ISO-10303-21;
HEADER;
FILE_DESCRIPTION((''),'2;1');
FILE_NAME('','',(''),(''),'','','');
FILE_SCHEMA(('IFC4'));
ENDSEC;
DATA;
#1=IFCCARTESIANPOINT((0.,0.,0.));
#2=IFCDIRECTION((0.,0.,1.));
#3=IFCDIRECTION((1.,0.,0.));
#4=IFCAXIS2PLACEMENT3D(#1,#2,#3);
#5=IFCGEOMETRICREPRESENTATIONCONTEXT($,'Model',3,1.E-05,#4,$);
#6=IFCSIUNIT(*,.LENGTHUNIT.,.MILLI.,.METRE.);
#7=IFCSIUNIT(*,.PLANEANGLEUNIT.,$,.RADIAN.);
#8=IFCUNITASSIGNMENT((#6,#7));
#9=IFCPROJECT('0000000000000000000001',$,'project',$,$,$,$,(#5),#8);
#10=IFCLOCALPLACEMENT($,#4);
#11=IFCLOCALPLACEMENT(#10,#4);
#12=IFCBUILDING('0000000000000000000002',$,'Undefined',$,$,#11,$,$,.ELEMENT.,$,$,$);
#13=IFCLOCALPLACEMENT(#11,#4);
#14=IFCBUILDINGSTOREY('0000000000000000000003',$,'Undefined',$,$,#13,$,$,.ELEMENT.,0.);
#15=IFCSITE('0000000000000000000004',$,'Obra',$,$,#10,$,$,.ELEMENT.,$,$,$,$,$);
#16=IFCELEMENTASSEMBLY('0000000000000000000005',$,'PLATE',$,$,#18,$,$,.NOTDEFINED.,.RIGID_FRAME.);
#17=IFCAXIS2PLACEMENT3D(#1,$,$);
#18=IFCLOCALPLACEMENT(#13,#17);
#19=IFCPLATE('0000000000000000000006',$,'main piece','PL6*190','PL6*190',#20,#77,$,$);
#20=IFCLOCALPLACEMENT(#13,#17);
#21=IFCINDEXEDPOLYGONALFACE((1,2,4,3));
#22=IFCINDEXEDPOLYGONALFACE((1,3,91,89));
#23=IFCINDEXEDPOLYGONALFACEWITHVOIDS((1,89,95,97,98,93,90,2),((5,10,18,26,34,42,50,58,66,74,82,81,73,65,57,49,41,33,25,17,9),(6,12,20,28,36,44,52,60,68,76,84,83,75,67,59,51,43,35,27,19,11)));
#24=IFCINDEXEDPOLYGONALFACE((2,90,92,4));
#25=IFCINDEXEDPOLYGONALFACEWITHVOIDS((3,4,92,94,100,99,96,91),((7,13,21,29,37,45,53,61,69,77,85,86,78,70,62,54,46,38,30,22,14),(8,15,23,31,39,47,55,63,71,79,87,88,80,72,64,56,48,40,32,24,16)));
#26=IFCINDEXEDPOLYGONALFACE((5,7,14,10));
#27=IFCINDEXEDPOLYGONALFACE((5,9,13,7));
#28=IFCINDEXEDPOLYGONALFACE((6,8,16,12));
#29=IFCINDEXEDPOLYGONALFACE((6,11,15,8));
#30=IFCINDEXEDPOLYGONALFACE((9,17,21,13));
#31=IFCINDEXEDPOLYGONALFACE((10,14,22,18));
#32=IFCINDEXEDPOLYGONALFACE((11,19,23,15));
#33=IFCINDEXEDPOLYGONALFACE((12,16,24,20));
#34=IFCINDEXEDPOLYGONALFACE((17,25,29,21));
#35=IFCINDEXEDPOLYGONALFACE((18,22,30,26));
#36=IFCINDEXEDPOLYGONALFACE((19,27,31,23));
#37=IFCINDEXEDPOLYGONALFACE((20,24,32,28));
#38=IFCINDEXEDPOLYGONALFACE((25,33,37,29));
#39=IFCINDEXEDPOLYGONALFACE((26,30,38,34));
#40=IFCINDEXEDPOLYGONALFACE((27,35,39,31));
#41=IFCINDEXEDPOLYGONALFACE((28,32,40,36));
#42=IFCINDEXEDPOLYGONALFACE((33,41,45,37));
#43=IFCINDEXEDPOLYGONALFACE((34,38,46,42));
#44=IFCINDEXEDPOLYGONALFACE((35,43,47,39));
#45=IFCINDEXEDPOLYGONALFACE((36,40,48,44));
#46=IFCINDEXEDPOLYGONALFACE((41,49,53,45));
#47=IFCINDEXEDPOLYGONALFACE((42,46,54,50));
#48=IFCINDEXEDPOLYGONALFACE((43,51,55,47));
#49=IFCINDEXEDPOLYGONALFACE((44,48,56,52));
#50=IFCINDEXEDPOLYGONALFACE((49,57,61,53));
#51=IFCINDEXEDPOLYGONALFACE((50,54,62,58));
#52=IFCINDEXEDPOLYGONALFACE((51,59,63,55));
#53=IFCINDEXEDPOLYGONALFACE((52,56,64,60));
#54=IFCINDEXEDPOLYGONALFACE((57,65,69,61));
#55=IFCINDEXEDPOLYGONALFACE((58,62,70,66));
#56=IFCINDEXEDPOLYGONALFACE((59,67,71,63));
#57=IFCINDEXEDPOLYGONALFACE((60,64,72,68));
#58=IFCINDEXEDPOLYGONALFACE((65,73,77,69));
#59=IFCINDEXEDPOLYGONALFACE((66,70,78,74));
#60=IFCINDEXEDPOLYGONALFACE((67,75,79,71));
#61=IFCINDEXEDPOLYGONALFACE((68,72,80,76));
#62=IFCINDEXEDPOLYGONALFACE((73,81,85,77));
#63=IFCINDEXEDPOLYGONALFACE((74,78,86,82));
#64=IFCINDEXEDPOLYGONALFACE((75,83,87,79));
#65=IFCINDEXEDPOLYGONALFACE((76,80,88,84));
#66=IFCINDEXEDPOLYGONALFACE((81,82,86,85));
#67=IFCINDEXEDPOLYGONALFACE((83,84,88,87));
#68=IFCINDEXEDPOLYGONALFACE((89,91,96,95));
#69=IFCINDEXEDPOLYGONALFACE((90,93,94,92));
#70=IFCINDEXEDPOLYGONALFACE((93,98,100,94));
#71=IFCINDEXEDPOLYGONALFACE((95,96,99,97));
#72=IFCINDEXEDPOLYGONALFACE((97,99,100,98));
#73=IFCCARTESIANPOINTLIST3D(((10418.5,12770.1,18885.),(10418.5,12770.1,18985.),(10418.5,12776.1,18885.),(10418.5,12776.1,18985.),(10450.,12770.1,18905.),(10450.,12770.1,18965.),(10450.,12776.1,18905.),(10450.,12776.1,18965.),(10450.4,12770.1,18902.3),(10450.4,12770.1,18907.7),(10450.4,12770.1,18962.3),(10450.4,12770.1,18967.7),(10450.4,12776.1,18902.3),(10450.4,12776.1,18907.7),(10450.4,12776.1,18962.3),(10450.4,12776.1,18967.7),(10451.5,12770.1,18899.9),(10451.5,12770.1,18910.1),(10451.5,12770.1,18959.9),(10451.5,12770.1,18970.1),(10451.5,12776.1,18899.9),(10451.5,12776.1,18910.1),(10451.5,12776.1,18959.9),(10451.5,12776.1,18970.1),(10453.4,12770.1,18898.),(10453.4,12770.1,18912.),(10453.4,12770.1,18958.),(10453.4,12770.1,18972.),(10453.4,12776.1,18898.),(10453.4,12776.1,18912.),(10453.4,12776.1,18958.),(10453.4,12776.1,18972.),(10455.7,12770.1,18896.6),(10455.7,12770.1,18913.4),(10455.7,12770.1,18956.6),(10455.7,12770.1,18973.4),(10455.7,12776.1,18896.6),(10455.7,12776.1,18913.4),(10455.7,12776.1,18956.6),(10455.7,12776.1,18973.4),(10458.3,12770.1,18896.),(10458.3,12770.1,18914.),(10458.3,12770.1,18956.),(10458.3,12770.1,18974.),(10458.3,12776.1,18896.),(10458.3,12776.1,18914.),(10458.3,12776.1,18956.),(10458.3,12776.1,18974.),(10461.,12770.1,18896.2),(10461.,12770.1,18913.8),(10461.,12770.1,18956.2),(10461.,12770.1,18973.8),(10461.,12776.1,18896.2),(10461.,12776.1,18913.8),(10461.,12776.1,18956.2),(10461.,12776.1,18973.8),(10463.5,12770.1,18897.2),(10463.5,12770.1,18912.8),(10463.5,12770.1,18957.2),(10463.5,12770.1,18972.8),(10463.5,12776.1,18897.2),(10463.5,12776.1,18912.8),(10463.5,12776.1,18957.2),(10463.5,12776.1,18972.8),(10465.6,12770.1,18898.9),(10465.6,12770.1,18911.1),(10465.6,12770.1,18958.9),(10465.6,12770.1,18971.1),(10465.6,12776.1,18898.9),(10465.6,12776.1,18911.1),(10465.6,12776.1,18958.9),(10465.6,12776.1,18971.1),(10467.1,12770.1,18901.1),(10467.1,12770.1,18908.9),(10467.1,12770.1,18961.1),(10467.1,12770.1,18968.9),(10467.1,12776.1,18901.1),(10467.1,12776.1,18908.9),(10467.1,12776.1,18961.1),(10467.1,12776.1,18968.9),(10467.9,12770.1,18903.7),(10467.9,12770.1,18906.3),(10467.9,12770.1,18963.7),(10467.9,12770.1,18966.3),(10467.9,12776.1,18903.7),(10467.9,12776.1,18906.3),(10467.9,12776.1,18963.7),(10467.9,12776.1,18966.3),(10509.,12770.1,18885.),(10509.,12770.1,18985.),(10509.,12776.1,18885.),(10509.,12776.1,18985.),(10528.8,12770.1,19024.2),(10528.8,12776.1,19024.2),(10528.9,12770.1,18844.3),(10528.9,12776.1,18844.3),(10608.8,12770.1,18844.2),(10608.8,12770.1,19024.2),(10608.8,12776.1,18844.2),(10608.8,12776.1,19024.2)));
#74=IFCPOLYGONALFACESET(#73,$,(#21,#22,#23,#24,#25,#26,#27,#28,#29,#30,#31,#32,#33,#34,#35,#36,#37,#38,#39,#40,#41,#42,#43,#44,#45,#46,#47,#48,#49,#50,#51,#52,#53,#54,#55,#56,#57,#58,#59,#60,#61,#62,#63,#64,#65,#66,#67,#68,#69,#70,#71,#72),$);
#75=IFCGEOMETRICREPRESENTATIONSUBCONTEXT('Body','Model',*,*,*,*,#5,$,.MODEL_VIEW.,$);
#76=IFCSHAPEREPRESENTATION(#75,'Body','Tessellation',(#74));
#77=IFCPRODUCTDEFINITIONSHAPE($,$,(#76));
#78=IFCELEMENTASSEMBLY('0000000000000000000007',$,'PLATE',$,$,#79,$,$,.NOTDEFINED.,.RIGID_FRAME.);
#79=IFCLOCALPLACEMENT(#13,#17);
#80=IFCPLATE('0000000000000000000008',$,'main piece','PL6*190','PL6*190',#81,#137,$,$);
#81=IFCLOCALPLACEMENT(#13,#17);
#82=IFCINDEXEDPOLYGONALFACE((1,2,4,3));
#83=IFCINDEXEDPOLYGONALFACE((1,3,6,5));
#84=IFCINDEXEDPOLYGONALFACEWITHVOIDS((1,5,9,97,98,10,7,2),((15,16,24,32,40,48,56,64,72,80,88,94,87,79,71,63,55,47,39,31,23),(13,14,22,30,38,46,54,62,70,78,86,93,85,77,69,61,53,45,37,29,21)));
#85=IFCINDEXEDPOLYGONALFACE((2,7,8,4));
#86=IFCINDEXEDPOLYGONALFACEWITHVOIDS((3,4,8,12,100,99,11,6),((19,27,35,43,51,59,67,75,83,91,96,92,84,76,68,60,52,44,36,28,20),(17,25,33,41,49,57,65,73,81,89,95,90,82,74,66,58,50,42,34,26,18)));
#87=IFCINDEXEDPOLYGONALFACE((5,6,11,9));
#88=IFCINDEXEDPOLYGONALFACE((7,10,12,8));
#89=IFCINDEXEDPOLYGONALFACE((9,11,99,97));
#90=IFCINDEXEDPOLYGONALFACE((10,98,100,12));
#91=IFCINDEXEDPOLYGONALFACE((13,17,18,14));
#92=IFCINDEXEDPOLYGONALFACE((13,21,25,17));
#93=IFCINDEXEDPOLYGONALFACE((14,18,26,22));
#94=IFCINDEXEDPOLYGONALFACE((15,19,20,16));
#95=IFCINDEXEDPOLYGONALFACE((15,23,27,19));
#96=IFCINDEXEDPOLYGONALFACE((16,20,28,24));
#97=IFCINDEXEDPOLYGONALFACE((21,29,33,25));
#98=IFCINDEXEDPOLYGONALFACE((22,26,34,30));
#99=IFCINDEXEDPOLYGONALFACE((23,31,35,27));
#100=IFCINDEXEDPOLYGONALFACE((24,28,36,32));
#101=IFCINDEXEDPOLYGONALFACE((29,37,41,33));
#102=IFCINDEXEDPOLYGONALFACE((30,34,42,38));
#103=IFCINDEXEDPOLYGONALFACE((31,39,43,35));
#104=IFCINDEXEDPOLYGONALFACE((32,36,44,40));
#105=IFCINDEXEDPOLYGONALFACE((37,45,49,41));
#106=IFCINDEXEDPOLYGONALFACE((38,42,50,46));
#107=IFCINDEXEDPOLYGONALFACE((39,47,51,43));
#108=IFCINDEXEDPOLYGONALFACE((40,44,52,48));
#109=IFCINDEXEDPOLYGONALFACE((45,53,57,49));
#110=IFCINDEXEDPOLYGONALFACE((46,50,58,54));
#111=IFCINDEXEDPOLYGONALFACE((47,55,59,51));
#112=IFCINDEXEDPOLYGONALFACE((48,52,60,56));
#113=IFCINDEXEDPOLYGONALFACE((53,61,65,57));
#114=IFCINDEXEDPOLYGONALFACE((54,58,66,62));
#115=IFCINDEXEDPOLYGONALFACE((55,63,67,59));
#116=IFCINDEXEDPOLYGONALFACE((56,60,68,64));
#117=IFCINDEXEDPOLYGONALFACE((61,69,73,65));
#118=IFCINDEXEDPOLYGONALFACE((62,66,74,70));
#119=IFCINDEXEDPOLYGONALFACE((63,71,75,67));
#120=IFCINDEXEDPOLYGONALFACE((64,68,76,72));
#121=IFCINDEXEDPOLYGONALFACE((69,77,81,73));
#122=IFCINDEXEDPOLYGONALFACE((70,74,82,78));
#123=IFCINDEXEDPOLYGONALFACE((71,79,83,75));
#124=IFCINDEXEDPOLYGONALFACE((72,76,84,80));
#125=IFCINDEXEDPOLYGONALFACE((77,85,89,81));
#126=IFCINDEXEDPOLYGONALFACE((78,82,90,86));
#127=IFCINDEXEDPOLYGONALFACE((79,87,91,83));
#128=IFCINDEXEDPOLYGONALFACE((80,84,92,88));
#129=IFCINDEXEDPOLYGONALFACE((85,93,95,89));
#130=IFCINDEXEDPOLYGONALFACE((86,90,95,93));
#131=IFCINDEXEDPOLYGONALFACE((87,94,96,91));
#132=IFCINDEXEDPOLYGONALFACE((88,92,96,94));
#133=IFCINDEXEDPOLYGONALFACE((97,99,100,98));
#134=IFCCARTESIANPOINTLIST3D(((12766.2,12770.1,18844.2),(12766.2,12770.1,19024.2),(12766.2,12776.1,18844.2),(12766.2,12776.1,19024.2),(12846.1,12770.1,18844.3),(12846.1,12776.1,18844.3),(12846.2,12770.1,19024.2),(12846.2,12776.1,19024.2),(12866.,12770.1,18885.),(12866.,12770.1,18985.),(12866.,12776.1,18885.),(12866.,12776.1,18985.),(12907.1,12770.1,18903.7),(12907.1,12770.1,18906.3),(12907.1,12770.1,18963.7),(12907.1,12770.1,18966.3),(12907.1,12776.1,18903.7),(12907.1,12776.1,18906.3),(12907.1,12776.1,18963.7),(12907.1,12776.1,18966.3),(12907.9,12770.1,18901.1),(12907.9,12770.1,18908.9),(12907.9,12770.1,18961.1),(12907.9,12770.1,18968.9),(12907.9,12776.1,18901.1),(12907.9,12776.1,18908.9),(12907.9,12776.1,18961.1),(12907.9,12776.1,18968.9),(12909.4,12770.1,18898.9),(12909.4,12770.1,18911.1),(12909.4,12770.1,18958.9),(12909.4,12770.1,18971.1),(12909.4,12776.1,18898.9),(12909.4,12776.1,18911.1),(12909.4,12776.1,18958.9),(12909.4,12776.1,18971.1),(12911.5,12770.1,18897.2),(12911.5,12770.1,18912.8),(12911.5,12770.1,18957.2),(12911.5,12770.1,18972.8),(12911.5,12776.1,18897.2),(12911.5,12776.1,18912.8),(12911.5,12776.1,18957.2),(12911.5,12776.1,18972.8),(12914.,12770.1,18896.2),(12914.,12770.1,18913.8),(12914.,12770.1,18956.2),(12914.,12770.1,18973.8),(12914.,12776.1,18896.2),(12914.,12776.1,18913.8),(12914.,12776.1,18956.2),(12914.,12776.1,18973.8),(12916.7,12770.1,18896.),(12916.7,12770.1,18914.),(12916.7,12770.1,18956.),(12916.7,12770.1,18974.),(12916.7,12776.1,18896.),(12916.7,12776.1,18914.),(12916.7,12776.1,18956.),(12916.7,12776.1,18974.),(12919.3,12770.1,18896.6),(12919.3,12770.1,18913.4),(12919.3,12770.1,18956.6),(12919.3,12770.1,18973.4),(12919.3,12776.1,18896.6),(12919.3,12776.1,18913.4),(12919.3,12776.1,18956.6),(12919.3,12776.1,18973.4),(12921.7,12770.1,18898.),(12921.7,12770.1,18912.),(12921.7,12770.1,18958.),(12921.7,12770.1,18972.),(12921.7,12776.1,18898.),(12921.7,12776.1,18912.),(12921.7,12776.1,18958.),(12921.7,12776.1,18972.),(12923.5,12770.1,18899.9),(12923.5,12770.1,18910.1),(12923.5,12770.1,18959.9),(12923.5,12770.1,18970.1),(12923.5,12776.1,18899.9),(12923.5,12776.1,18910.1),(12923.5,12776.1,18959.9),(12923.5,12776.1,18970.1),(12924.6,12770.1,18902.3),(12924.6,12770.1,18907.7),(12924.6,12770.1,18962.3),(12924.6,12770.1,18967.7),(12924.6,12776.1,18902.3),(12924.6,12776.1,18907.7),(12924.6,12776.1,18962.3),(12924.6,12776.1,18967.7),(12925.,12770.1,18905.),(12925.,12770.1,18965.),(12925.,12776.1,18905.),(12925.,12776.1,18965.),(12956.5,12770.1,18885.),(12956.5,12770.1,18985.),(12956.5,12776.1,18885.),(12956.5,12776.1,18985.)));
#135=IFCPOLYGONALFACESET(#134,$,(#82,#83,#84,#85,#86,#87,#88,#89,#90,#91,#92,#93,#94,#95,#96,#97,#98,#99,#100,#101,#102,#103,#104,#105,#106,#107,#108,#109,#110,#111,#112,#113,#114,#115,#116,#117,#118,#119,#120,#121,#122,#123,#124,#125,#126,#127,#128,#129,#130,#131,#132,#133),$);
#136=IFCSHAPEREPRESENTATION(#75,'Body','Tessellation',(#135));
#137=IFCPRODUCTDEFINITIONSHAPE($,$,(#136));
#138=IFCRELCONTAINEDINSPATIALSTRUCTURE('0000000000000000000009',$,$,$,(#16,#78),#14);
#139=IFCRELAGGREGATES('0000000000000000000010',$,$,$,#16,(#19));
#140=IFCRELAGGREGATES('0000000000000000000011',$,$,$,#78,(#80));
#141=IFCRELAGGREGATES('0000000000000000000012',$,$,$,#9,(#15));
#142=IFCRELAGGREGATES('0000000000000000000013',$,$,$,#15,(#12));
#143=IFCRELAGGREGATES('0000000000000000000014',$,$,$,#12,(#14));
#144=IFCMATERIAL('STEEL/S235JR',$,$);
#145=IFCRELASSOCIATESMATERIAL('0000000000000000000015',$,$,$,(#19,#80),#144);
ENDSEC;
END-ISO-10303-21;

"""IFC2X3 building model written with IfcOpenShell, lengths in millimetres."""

from ifc_helpers import new_model, si_unit, frame, origin_with_axes, origin_2d_with_axis, place, context, subcontext, project, spatial, polyline, circle, outline, extrude, source, transform, mapped, material, element, aggregate, save


model = new_model("IFC2X3")

# Units and contexts
model_context = context("Model", 3, precision=1e-05, world=origin_with_axes())
body_context = subcontext(model_context, "Body", "Model", "MODEL_VIEW")
ifc_project = project(units=[si_unit("LENGTHUNIT", "METRE", prefix="MILLI"), si_unit("PLANEANGLEUNIT", "RADIAN")], contexts=[model_context])

# Site, building, storey
site_placement = place(None, origin_with_axes())
site = spatial("IfcSite", under=ifc_project, at=site_placement, Name="Obra", CompositionType="ELEMENT")
building_placement = place(site_placement, origin_with_axes())
building = spatial("IfcBuilding", under=site, at=building_placement, Name="Undefined", CompositionType="ELEMENT")
storey_placement = place(building_placement, origin_with_axes())
storey = spatial("IfcBuildingStorey", under=building, at=storey_placement, Name="Undefined", CompositionType="ELEMENT", Elevation=0.0)

# Shared definitions
ifc_material_1 = material(Name="STEEL/S235JR")

# Element assemblies, plates, openings
shared_shape_1 = source(origin_with_axes(), body_context, "Body", "SweptSolid", [
    extrude(circle(Radius=9.0, at=origin_2d_with_axis()), frame((0.0, -6.1, 0.0), z_axis=(0.0, 1.0, 0.0), x_axis=(1.0, 0.0, 0.0)), (0.0, 0.0, 1.0), 6.2),
])
assembly_1_placement = place(storey_placement, origin_with_axes())
assembly_1 = element("IfcElementAssembly", 1, at=assembly_1_placement, inside=storey, Name="PLATE", AssemblyPlace="NOTDEFINED", PredefinedType="RIGID_FRAME")
plate_1_placement = place(assembly_1_placement, frame((10608.8, 12773.1, 19024.2), z_axis=(0.0, 1.0, 0.0), x_axis=(0.0, 0.0, -1.0)))
plate_1 = element("IfcPlate", 2, at=plate_1_placement, material=ifc_material_1, Name="main piece", Description="PL6*190", ObjectType="PL6*190", context=body_context, shape_type="SweptSolid", body=[
    extrude(outline(polyline([(0.0, 0.0), (180.0, 0.0), (180.0, 79.9), (139.2, 99.8), (139.2, 190.3), (39.2, 190.3), (39.2, 99.8), (0.0, 80.0), (0.0, 0.0)])), frame((0.0, 0.0, -3.0), z_axis=(0.0, 0.0, 1.0), x_axis=(1.0, 0.0, 0.0)), (0.0, 0.0, 1.0), 6.0),
])
opening_1_placement = place(assembly_1_placement, frame((10459.0, 12770.1, 18935.0), z_axis=(0.0, 0.0, 1.0), x_axis=(-1.0, 0.0, 0.0)))
element("IfcOpeningElement", 3, at=opening_1_placement, cuts=plate_1, ObjectType="Opening", context=body_context, shape_type="MappedRepresentation", body=[
    mapped(shared_shape_1, transform((0.0, 0.0, -30.0))),
    mapped(shared_shape_1, transform((0.0, 0.0, 30.0))),
])
aggregate(assembly_1, [plate_1])
assembly_2_placement = place(storey_placement, origin_with_axes())
assembly_2 = element("IfcElementAssembly", 4, at=assembly_2_placement, inside=storey, Name="PLATE", AssemblyPlace="NOTDEFINED", PredefinedType="RIGID_FRAME")
plate_2_placement = place(assembly_2_placement, frame((12766.2, 12773.1, 19024.2), z_axis=(0.0, -1.0, 0.0), x_axis=(0.0, 0.0, -1.0)))
plate_2 = element("IfcPlate", 5, at=plate_2_placement, material=ifc_material_1, Name="main piece", Description="PL6*190", ObjectType="PL6*190", context=body_context, shape_type="SweptSolid", body=[
    extrude(outline(polyline([(0.0, 0.0), (180.0, 0.0), (180.0, 79.9), (139.2, 99.8), (139.2, 190.3), (39.2, 190.3), (39.2, 99.8), (0.0, 80.0), (0.0, 0.0)])), frame((0.0, 0.0, -3.0), z_axis=(0.0, 0.0, 1.0), x_axis=(1.0, 0.0, 0.0)), (0.0, 0.0, 1.0), 6.0),
])
opening_2_placement = place(assembly_2_placement, frame((12916.0, 12770.1, 18935.0), z_axis=(0.0, 0.0, -1.0), x_axis=(1.0, 0.0, 0.0)))
element("IfcOpeningElement", 6, at=opening_2_placement, cuts=plate_2, ObjectType="Opening", context=body_context, shape_type="MappedRepresentation", body=[
    mapped(shared_shape_1, transform((0.0, 0.0, 30.0))),
    mapped(shared_shape_1, transform((0.0, 0.0, -30.0))),
])

aggregate(assembly_2, [plate_2])

save(model, "model.ifc")
